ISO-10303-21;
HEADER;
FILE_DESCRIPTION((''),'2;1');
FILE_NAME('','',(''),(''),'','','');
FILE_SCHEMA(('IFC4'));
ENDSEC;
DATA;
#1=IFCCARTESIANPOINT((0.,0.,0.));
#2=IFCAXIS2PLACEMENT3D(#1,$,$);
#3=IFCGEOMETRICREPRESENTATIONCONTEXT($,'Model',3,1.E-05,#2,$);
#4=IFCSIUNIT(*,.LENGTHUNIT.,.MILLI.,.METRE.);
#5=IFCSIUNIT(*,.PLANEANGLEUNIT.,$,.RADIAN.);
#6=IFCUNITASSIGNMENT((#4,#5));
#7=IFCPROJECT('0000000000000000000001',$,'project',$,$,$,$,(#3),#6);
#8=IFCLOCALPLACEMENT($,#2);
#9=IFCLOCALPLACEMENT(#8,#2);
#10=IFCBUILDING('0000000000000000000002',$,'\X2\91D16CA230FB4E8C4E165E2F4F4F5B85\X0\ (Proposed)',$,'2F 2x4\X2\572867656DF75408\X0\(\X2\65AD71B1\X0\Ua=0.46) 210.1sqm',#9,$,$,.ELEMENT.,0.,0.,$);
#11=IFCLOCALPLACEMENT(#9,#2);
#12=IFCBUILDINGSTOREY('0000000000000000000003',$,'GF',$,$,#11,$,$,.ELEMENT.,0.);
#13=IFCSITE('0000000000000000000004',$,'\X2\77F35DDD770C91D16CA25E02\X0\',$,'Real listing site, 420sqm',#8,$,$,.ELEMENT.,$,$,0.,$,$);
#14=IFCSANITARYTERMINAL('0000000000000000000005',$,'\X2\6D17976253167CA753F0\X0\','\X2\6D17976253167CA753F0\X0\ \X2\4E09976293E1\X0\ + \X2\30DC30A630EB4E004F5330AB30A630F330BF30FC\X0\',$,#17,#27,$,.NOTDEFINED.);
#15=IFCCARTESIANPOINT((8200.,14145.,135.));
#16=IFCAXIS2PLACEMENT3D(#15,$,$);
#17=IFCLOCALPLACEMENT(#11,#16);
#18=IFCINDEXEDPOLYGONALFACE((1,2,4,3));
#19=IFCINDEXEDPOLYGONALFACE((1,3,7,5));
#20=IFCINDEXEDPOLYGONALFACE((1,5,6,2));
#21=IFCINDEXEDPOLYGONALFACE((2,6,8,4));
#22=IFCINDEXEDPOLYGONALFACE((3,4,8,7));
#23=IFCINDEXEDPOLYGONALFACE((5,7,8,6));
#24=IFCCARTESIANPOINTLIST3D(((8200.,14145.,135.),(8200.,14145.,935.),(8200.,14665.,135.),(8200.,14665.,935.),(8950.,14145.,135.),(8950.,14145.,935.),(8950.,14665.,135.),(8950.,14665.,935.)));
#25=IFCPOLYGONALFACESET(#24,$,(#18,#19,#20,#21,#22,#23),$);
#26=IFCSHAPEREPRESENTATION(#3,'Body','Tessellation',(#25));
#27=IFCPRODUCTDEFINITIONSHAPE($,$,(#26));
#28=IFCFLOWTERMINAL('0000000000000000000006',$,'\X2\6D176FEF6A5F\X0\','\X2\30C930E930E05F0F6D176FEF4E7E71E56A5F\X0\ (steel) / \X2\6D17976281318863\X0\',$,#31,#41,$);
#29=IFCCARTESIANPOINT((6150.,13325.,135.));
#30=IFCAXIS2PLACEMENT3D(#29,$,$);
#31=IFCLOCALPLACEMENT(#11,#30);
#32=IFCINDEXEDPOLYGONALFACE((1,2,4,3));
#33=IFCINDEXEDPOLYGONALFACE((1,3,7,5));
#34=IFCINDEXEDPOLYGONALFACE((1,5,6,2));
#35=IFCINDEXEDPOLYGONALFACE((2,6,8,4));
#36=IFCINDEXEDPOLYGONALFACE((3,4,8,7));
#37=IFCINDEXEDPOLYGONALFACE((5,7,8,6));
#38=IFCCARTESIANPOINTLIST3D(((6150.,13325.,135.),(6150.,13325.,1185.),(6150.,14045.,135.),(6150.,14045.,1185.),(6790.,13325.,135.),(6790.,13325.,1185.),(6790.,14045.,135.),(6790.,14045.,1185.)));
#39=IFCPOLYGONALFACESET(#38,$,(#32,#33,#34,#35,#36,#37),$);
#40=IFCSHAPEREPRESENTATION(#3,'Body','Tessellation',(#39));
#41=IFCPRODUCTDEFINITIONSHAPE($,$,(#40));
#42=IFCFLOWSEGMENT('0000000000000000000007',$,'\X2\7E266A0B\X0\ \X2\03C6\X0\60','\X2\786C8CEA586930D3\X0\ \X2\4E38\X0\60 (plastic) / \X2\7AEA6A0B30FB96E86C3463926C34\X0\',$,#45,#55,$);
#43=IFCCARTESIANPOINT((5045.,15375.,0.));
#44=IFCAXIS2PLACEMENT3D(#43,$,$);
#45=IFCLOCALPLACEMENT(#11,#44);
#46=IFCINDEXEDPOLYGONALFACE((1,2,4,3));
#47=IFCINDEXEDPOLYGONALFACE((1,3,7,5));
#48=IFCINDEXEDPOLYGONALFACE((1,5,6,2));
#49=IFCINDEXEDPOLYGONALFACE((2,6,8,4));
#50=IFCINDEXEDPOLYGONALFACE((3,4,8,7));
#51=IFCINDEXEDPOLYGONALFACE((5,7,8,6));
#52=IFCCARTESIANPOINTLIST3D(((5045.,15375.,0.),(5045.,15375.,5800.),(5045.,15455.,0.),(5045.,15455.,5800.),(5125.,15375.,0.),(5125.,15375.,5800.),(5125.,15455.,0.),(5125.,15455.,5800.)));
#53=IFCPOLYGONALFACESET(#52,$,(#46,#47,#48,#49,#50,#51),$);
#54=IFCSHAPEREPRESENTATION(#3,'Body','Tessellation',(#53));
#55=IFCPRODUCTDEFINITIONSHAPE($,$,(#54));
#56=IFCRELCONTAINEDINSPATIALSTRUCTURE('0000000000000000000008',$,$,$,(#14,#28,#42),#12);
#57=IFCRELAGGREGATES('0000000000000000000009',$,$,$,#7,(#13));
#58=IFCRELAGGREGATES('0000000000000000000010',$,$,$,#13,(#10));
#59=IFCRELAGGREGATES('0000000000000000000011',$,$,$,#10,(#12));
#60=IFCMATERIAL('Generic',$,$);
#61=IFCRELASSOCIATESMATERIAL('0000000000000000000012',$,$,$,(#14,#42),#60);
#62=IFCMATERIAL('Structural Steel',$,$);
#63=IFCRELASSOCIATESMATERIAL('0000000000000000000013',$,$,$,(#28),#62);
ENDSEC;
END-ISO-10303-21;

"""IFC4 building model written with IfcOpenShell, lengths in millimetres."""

from ifc_helpers import new_model, si_unit, frame, frame_2d, origin, place, context, project, spatial, rectangle, extrude, material, element, save


model = new_model("IFC4")

# Units and contexts
model_context = context("Model", 3, precision=1e-05, world=origin())
ifc_project = project(units=[si_unit("LENGTHUNIT", "METRE", prefix="MILLI"), si_unit("PLANEANGLEUNIT", "RADIAN")], contexts=[model_context])

# Site, building, storey
site_placement = place(None, origin())
site = spatial("IfcSite", under=ifc_project, at=site_placement, Name="石川県金沢市", ObjectType="Real listing site, 420sqm", CompositionType="ELEMENT", RefElevation=0.0)
building_placement = place(site_placement, origin())
building = spatial("IfcBuilding", under=site, at=building_placement, Name="金沢・二世帯住宅 (Proposed)", ObjectType="2F 2x4在来混合(断熱Ua=0.46) 210.1sqm", CompositionType="ELEMENT", ElevationOfRefHeight=0.0, ElevationOfTerrain=0.0)
storey_placement = place(building_placement, origin())
storey = spatial("IfcBuildingStorey", under=building, at=storey_placement, Name="GF", CompositionType="ELEMENT", Elevation=0.0)

# Sanitary terminal
ifc_material_1 = material(Name="Generic")
sanitary_terminal_placement = place(storey_placement, frame((8200.0, 14145.0, 135.0)))
element("IfcSanitaryTerminal", 1, at=sanitary_terminal_placement, inside=storey, material=ifc_material_1, Name="洗面化粧台", Description="洗面化粧台 三面鏡 + ボウル一体カウンター", PredefinedType="NOTDEFINED", context=model_context, shape_type="SweptSolid", body=[
    extrude(rectangle(XDim=750.0, YDim=520.0, at=frame_2d((375.0, 260.0))), frame((8200.0, 14145.0, 135.0)), (0.0, 0.0, 1.0), 800.0),
])

# Flow terminal
ifc_material_2 = material(Name="Structural Steel")
flow_terminal_placement = place(storey_placement, frame((6150.0, 13325.0, 135.0)))
element("IfcFlowTerminal", 2, at=flow_terminal_placement, inside=storey, material=ifc_material_2, Name="洗濯機", Description="ドラム式洗濯乾燥機 (steel) / 洗面脱衣", context=model_context, shape_type="SweptSolid", body=[
    extrude(rectangle(XDim=640.0, YDim=720.0, at=frame_2d((320.0, 360.0))), frame((6150.0, 13325.0, 135.0)), (0.0, 0.0, 1.0), 1050.0),
])

# Flow segment
flow_segment_1_placement = place(storey_placement, frame((5045.0, 15375.0, 0.0)))
element("IfcFlowSegment", 3, at=flow_segment_1_placement, inside=storey, material=ifc_material_1, Name="縦樋 φ60", Description="硬質塩ビ 丸60 (plastic) / 竪樋・雨水排水", context=model_context, shape_type="SweptSolid", body=[
    extrude(rectangle(XDim=80.0, YDim=80.0, at=frame_2d((40.0, 40.0))), frame((5045.0, 15375.0, 0.0)), (0.0, 0.0, 1.0), 5800.0),
])

save(model, "model.ifc")
